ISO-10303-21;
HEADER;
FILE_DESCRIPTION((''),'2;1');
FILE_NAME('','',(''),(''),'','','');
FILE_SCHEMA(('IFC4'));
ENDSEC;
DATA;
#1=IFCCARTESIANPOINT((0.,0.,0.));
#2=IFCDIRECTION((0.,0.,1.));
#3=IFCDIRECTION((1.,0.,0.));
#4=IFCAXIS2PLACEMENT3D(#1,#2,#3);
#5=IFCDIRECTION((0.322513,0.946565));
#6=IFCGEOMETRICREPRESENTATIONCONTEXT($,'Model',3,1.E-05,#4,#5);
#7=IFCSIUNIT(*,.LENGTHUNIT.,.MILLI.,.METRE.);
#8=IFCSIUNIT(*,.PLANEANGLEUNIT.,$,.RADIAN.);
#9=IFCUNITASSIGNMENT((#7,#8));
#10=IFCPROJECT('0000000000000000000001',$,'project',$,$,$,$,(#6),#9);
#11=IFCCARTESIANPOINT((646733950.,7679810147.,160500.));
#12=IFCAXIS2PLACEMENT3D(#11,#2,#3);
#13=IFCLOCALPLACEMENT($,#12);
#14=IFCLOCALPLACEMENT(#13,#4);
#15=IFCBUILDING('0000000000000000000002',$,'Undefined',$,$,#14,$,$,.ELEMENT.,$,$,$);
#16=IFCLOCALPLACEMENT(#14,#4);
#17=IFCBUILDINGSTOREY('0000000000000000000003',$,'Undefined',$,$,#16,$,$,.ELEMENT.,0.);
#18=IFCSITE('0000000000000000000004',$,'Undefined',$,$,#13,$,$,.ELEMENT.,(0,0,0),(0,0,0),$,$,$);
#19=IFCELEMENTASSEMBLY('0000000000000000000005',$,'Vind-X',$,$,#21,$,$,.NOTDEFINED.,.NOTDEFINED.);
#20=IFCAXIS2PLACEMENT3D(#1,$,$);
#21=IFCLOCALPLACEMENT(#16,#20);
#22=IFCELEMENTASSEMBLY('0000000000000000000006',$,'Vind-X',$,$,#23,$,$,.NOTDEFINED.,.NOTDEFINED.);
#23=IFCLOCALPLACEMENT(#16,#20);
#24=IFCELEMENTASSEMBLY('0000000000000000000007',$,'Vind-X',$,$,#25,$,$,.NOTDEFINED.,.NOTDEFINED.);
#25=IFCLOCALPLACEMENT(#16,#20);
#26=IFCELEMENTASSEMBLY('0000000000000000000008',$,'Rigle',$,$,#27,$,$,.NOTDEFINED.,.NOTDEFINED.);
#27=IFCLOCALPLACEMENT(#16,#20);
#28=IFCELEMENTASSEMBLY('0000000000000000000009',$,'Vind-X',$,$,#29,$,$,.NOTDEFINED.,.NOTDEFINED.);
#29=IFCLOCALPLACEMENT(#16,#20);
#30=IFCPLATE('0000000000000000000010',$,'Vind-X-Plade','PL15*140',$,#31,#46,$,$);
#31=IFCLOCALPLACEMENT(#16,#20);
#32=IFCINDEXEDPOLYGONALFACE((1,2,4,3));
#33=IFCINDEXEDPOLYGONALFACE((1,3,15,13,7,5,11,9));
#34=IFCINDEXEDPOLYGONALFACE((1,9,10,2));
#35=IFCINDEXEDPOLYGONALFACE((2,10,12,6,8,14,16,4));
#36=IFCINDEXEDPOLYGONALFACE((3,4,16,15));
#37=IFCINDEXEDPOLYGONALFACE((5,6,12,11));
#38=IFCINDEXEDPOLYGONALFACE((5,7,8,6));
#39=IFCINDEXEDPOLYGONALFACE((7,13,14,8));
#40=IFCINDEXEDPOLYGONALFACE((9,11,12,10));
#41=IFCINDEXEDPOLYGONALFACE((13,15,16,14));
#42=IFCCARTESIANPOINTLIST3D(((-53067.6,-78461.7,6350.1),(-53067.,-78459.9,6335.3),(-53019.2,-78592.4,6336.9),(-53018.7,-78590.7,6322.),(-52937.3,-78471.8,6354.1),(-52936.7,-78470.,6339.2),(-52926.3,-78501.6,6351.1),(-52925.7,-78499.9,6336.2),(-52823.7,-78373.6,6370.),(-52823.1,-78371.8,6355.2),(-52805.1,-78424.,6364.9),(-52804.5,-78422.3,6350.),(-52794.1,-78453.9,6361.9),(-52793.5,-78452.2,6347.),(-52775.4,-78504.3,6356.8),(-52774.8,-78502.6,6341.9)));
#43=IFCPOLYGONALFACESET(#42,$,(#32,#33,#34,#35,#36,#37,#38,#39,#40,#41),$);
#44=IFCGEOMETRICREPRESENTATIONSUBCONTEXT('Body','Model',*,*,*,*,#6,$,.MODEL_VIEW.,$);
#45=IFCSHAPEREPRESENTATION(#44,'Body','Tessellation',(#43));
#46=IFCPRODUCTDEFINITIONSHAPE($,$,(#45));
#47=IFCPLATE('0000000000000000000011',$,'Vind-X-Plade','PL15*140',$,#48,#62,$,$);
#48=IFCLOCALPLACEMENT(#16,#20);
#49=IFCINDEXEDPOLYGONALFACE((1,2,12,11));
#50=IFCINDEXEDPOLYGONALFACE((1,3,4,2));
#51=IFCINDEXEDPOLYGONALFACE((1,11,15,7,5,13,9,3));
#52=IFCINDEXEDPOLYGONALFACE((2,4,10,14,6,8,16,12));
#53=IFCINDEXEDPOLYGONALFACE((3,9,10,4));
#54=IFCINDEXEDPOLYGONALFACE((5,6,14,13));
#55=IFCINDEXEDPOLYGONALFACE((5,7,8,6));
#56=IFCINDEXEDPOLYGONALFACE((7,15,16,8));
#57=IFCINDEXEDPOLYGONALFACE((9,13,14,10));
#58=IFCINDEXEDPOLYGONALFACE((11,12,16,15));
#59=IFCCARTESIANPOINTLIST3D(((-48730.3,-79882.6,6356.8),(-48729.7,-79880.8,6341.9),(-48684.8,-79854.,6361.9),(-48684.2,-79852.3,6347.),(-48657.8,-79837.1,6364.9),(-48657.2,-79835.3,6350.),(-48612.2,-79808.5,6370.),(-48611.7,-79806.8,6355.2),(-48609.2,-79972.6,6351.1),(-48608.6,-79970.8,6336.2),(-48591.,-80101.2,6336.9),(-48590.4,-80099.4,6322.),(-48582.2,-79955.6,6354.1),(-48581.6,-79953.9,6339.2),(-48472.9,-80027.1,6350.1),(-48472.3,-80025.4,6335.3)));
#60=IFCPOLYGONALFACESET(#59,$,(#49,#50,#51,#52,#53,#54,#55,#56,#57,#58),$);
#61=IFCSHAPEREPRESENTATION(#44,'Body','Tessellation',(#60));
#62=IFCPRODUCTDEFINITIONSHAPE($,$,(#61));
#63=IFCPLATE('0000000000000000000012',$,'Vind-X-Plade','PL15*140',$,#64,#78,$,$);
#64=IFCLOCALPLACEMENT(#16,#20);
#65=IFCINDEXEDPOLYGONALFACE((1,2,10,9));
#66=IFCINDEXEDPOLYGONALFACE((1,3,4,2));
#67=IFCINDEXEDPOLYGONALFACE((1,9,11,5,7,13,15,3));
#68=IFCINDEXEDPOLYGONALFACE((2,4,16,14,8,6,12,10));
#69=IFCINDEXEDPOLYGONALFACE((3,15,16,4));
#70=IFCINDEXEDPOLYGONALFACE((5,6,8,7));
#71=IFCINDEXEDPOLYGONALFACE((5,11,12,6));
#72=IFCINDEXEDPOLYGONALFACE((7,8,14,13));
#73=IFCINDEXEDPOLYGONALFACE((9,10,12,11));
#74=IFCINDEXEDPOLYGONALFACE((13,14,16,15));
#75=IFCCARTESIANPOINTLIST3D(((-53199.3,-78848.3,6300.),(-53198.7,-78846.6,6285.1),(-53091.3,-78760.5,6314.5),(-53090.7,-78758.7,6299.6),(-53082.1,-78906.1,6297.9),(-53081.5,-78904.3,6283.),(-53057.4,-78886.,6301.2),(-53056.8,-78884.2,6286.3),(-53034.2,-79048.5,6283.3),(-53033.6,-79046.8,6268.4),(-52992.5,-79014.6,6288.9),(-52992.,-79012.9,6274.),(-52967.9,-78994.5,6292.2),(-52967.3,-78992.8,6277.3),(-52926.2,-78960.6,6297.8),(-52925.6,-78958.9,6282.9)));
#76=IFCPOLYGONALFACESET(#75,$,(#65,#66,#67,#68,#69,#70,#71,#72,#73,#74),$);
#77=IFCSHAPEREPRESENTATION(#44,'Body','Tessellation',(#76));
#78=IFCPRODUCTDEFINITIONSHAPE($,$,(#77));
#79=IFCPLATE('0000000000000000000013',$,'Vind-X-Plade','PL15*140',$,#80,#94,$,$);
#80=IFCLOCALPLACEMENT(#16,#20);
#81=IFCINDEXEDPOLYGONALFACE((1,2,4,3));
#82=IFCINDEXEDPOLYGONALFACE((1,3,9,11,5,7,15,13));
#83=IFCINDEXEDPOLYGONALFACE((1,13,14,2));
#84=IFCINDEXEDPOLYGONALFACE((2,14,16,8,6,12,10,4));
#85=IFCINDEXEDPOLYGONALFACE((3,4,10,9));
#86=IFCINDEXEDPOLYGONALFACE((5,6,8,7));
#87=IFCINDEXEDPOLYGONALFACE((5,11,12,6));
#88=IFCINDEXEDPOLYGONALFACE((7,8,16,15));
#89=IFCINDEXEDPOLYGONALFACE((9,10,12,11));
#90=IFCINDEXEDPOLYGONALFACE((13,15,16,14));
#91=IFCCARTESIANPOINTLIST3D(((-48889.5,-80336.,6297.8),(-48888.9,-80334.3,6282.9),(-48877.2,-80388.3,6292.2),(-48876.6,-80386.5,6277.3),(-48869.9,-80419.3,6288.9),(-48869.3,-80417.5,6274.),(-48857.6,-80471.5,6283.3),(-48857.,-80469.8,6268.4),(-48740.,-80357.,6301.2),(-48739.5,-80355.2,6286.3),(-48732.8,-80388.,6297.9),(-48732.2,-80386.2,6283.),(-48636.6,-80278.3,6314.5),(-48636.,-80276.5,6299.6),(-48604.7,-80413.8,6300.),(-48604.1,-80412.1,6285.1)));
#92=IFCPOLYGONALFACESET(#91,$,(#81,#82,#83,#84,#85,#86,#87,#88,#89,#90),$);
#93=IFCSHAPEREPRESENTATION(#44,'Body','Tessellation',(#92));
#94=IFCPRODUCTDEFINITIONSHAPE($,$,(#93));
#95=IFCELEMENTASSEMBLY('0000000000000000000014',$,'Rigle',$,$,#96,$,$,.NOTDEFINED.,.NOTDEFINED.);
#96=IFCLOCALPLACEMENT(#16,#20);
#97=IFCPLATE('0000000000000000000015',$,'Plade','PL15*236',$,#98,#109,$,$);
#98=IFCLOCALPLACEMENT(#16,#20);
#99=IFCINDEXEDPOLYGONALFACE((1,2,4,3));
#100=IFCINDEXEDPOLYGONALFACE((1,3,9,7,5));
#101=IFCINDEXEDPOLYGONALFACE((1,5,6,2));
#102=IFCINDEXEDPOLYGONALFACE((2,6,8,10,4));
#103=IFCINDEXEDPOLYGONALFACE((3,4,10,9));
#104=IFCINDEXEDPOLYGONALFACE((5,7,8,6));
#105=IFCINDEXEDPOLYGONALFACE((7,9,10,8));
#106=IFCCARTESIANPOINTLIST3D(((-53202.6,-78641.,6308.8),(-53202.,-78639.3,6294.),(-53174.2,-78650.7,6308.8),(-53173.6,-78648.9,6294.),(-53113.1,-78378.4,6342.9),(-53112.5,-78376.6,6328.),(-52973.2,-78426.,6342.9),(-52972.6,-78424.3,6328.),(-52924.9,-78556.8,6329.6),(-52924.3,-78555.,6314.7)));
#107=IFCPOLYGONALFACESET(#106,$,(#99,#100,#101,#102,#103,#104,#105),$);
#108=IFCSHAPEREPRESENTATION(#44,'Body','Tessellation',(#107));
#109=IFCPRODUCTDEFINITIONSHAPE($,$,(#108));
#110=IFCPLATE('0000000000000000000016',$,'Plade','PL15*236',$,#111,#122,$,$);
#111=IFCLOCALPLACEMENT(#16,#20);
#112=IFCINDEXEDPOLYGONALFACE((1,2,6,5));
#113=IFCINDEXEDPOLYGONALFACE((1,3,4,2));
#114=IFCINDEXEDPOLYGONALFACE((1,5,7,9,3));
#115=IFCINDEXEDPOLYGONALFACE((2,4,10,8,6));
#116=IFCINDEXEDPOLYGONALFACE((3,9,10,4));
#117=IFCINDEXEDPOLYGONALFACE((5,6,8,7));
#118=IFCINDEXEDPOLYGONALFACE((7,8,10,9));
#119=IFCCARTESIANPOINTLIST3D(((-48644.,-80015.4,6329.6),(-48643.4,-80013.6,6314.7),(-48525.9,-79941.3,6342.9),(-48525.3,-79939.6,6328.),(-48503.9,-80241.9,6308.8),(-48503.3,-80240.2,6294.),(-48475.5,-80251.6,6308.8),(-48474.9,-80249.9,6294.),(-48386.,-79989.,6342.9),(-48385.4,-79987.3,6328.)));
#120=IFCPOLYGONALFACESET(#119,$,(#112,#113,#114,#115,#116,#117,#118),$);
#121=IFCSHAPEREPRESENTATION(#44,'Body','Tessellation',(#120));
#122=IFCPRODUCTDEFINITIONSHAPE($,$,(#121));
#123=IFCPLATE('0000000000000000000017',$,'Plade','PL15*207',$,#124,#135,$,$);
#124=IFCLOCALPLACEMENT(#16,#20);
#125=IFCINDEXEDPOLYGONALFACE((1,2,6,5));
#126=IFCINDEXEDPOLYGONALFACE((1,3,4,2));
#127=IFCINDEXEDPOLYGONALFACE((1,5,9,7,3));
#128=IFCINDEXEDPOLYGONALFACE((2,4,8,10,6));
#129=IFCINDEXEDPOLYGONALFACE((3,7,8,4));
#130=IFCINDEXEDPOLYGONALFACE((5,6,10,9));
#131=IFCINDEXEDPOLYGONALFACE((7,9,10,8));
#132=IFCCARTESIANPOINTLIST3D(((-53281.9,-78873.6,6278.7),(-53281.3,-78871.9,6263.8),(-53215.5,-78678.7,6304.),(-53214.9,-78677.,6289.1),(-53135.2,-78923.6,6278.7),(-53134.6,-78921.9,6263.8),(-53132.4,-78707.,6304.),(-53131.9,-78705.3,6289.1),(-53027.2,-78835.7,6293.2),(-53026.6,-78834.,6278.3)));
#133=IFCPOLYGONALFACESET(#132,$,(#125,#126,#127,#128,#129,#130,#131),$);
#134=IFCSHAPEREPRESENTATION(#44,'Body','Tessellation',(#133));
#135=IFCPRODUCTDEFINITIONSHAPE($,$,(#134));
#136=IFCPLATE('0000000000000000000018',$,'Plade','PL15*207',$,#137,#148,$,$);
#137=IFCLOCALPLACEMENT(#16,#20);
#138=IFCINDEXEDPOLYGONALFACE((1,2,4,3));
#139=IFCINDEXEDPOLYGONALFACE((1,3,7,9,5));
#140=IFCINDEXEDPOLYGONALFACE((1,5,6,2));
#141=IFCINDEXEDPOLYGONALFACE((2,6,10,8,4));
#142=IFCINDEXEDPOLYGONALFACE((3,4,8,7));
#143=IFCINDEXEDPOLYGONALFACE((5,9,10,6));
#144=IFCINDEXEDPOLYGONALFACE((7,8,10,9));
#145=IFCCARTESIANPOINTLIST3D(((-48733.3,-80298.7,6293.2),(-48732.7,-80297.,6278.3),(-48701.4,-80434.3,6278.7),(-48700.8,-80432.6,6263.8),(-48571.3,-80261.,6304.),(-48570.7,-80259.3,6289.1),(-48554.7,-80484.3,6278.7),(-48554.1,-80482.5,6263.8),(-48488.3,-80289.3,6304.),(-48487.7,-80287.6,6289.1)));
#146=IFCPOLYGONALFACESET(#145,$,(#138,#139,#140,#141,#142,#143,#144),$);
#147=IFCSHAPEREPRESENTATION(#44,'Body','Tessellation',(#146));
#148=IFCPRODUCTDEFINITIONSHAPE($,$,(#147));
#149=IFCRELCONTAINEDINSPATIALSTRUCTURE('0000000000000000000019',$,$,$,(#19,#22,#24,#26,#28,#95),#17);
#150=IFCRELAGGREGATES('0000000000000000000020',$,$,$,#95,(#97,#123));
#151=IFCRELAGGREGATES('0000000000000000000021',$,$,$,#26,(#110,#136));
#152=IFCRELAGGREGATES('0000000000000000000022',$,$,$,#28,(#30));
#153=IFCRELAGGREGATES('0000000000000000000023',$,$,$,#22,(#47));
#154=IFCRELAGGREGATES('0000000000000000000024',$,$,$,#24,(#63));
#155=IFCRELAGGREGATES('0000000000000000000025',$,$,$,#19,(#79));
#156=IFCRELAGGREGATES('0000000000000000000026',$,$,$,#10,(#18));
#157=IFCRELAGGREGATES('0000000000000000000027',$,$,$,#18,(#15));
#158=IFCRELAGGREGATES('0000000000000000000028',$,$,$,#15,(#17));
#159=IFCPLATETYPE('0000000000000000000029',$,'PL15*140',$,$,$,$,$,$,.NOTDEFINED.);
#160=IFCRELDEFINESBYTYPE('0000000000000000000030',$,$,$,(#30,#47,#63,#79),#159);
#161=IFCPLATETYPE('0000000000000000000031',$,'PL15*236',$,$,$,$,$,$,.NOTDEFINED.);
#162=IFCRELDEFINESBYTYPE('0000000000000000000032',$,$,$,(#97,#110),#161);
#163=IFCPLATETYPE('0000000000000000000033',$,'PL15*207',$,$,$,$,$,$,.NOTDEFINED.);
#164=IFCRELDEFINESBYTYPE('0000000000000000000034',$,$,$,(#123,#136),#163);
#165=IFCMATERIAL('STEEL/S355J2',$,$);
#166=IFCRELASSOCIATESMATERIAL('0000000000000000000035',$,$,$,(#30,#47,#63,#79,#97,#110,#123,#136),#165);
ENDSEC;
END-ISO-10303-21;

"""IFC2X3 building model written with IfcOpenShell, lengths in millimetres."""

from ifc_helpers import new_model, si_unit, direction, frame, origin_with_axes, place, context, subcontext, project, spatial, polyline, outline, extrude, material, type_object, element, aggregate, save


model = new_model("IFC2X3")

# Units and contexts
model_context = context("Model", 3, precision=1e-05, world=origin_with_axes(), true_north=direction((0.322513, 0.946565)))
body_context = subcontext(model_context, "Body", "Model", "MODEL_VIEW")
ifc_project = project(units=[si_unit("LENGTHUNIT", "METRE", prefix="MILLI"), si_unit("PLANEANGLEUNIT", "RADIAN")], contexts=[model_context])

# Site, building, storey
site_placement = place(None, frame((646733950.0, 7679810147.0, 160500.0), z_axis=(0.0, 0.0, 1.0), x_axis=(1.0, 0.0, 0.0)))
site = spatial("IfcSite", under=ifc_project, at=site_placement, Name="Undefined", CompositionType="ELEMENT", RefLatitude=(0, 0, 0), RefLongitude=(0, 0, 0))
building_placement = place(site_placement, origin_with_axes())
building = spatial("IfcBuilding", under=site, at=building_placement, Name="Undefined", CompositionType="ELEMENT")
storey_placement = place(building_placement, origin_with_axes())
storey = spatial("IfcBuildingStorey", under=building, at=storey_placement, Name="Undefined", CompositionType="ELEMENT", Elevation=0.0)

# Element assemblies
assembly_1_placement = place(storey_placement, origin_with_axes())
assembly_1 = element("IfcElementAssembly", 1, at=assembly_1_placement, inside=storey, Name="Vind-X", AssemblyPlace="NOTDEFINED", PredefinedType="NOTDEFINED")
ifc_material_1 = material(Name="STEEL/S355J2")
assembly_2_placement = place(storey_placement, origin_with_axes())
assembly_2 = element("IfcElementAssembly", 2, at=assembly_2_placement, inside=storey, Name="Vind-X", AssemblyPlace="NOTDEFINED", PredefinedType="NOTDEFINED")

# Element assembly
assembly_3_placement = place(storey_placement, origin_with_axes())
assembly_3 = element("IfcElementAssembly", 3, at=assembly_3_placement, inside=storey, Name="Vind-X", AssemblyPlace="NOTDEFINED", PredefinedType="NOTDEFINED")

# Element assemblies, plate
assembly_4_placement = place(storey_placement, origin_with_axes())
assembly_4 = element("IfcElementAssembly", 4, at=assembly_4_placement, inside=storey, Name="Rigle", AssemblyPlace="NOTDEFINED", PredefinedType="NOTDEFINED")
assembly_5_placement = place(storey_placement, origin_with_axes())
assembly_5 = element("IfcElementAssembly", 5, at=assembly_5_placement, inside=storey, Name="Vind-X", AssemblyPlace="NOTDEFINED", PredefinedType="NOTDEFINED")
plate_type_1 = type_object("IfcPlateType", Name="PL15*140", PredefinedType="NOTDEFINED")
plate_1_placement = place(assembly_5_placement, frame((-52823.4, -78372.7, 6362.6), z_axis=(-0.039304, -0.115357, 0.992546), x_axis=(-0.937758, -0.338759, -0.076507)))
plate_1 = element("IfcPlate", 6, at=plate_1_placement, type_object=plate_type_1, material=ifc_material_1, Name="Vind-X-Plade", Description="PL15*140", context=body_context, shape_type="SweptSolid", body=[
    extrude(outline(polyline([(0.0, 0.0), (260.0, 0.0), (260.0, 140.0), (0.0, 140.0), (0.0, 86.0), (141.0, 86.0), (141.0, 54.0), (0.0, 54.0), (0.0, 0.0)])), frame((0.0, 0.0, -7.5), z_axis=(0.0, 0.0, 1.0), x_axis=(1.0, 0.0, 0.0)), (0.0, 0.0, 1.0), 15.0),
])

# Plates
plate_2_placement = place(assembly_2_placement, frame((-48730.0, -79881.7, 6349.3), z_axis=(-0.039304, -0.115357, 0.992546), x_axis=(0.535845, -0.840843, -0.076507)))
plate_2 = element("IfcPlate", 7, at=plate_2_placement, type_object=plate_type_1, material=ifc_material_1, Name="Vind-X-Plade", Description="PL15*140", context=body_context, shape_type="SweptSolid", body=[
    extrude(outline(polyline([(0.0, 0.0), (260.0, 0.0), (260.0, 140.0), (0.0, 140.0), (0.0, 86.0), (141.0, 86.0), (141.0, 54.0), (0.0, 54.0), (0.0, 0.0)])), frame((0.0, 0.0, -7.5), z_axis=(0.0, 0.0, 1.0), x_axis=(1.0, 0.0, 0.0)), (0.0, 0.0, 1.0), 15.0),
])
plate_3_placement = place(assembly_3_placement, frame((-52925.9, -78959.8, 6290.3), z_axis=(-0.039304, -0.115357, 0.992546), x_axis=(-0.634983, 0.769843, 0.064329)))
plate_3 = element("IfcPlate", 8, at=plate_3_placement, type_object=plate_type_1, material=ifc_material_1, Name="Vind-X-Plade", Description="PL15*140", context=body_context, shape_type="SweptSolid", body=[
    extrude(outline(polyline([(0.0, 0.0), (260.0, 0.0), (260.0, 140.0), (0.0, 140.0), (0.0, 86.0), (141.0, 86.0), (141.0, 54.0), (0.0, 54.0), (0.0, 0.0)])), frame((0.0, 0.0, -7.5), z_axis=(0.0, 0.0, 1.0), x_axis=(1.0, 0.0, 0.0)), (0.0, 0.0, 1.0), 15.0),
])
plate_4_placement = place(assembly_1_placement, frame((-48857.3, -80470.7, 6275.8), z_axis=(-0.039304, -0.115357, 0.992546), x_axis=(0.972923, 0.221999, 0.064329)))
plate_4 = element("IfcPlate", 9, at=plate_4_placement, type_object=plate_type_1, material=ifc_material_1, Name="Vind-X-Plade", Description="PL15*140", context=body_context, shape_type="SweptSolid", body=[
    extrude(outline(polyline([(0.0, 0.0), (260.0, 0.0), (260.0, 140.0), (0.0, 140.0), (0.0, 86.0), (141.0, 86.0), (141.0, 54.0), (0.0, 54.0), (0.0, 0.0)])), frame((0.0, 0.0, -7.5), z_axis=(0.0, 0.0, 1.0), x_axis=(1.0, 0.0, 0.0)), (0.0, 0.0, 1.0), 15.0),
])

# Element assembly, plate
assembly_6_placement = place(storey_placement, origin_with_axes())
assembly_6 = element("IfcElementAssembly", 10, at=assembly_6_placement, inside=storey, Name="Rigle", AssemblyPlace="NOTDEFINED", PredefinedType="NOTDEFINED")
plate_type_2 = type_object("IfcPlateType", Name="PL15*236", PredefinedType="NOTDEFINED")
plate_5_placement = place(assembly_6_placement, frame((-53112.8, -78377.5, 6335.5), z_axis=(-0.039304, -0.115357, 0.992546), x_axis=(-0.320109, -0.93951, -0.121869)))
plate_5 = element("IfcPlate", 11, at=plate_5_placement, type_object=plate_type_2, material=ifc_material_1, Name="Plade", Description="PL15*236", context=body_context, shape_type="SweptSolid", body=[
    extrude(outline(polyline([(0.0, 0.0), (279.5, 0.0), (279.5, 30.0), (109.0, 235.7), (0.0, 147.8), (0.0, 0.0)])), frame((0.0, 0.0, -7.5), z_axis=(0.0, 0.0, 1.0), x_axis=(1.0, 0.0, 0.0)), (0.0, 0.0, 1.0), 15.0),
])

# Plates
plate_6_placement = place(assembly_4_placement, frame((-48475.2, -80250.8, 6301.4), z_axis=(-0.039304, -0.115357, 0.992546), x_axis=(0.320109, 0.93951, 0.121869)))
plate_6 = element("IfcPlate", 12, at=plate_6_placement, type_object=plate_type_2, material=ifc_material_1, Name="Plade", Description="PL15*236", context=body_context, shape_type="SweptSolid", body=[
    extrude(outline(polyline([(0.0, 0.0), (279.5, 0.0), (279.5, 147.8), (170.6, 235.7), (0.0, 30.0), (0.0, 0.0)])), frame((0.0, 0.0, -7.5), z_axis=(0.0, 0.0, 1.0), x_axis=(1.0, 0.0, 0.0)), (0.0, 0.0, 1.0), 15.0),
])
plate_type_3 = type_object("IfcPlateType", Name="PL15*207", PredefinedType="NOTDEFINED")
plate_7_placement = place(assembly_6_placement, frame((-53215.2, -78677.8, 6296.5), z_axis=(-0.039304, -0.115357, 0.992546), x_axis=(-0.320109, -0.93951, -0.121869)))
plate_7 = element("IfcPlate", 13, at=plate_7_placement, type_object=plate_type_3, material=ifc_material_1, Name="Plade", Description="PL15*207", context=body_context, shape_type="SweptSolid", body=[
    extrude(outline(polyline([(0.0, 0.0), (207.5, 0.0), (207.5, 154.9), (88.6, 228.8), (0.0, 87.7), (0.0, 0.0)])), frame((0.0, 0.0, -7.5), z_axis=(0.0, 0.0, 1.0), x_axis=(1.0, 0.0, 0.0)), (0.0, 0.0, 1.0), 15.0),
])
aggregate(assembly_6, [plate_5, plate_7])
plate_8_placement = place(assembly_4_placement, frame((-48554.4, -80483.4, 6271.2), z_axis=(-0.039304, -0.115357, 0.992546), x_axis=(0.320109, 0.93951, 0.121869)))
plate_8 = element("IfcPlate", 14, at=plate_8_placement, type_object=plate_type_3, material=ifc_material_1, Name="Plade", Description="PL15*207", context=body_context, shape_type="SweptSolid", body=[
    extrude(outline(polyline([(0.0, 0.0), (207.5, 0.0), (207.5, 87.7), (118.9, 228.8), (0.0, 154.9), (0.0, 0.0)])), frame((0.0, 0.0, -7.5), z_axis=(0.0, 0.0, 1.0), x_axis=(1.0, 0.0, 0.0)), (0.0, 0.0, 1.0), 15.0),
])

aggregate(assembly_4, [plate_6, plate_8])
aggregate(assembly_5, [plate_1])
aggregate(assembly_2, [plate_2])
aggregate(assembly_3, [plate_3])
aggregate(assembly_1, [plate_4])

save(model, "model.ifc")
